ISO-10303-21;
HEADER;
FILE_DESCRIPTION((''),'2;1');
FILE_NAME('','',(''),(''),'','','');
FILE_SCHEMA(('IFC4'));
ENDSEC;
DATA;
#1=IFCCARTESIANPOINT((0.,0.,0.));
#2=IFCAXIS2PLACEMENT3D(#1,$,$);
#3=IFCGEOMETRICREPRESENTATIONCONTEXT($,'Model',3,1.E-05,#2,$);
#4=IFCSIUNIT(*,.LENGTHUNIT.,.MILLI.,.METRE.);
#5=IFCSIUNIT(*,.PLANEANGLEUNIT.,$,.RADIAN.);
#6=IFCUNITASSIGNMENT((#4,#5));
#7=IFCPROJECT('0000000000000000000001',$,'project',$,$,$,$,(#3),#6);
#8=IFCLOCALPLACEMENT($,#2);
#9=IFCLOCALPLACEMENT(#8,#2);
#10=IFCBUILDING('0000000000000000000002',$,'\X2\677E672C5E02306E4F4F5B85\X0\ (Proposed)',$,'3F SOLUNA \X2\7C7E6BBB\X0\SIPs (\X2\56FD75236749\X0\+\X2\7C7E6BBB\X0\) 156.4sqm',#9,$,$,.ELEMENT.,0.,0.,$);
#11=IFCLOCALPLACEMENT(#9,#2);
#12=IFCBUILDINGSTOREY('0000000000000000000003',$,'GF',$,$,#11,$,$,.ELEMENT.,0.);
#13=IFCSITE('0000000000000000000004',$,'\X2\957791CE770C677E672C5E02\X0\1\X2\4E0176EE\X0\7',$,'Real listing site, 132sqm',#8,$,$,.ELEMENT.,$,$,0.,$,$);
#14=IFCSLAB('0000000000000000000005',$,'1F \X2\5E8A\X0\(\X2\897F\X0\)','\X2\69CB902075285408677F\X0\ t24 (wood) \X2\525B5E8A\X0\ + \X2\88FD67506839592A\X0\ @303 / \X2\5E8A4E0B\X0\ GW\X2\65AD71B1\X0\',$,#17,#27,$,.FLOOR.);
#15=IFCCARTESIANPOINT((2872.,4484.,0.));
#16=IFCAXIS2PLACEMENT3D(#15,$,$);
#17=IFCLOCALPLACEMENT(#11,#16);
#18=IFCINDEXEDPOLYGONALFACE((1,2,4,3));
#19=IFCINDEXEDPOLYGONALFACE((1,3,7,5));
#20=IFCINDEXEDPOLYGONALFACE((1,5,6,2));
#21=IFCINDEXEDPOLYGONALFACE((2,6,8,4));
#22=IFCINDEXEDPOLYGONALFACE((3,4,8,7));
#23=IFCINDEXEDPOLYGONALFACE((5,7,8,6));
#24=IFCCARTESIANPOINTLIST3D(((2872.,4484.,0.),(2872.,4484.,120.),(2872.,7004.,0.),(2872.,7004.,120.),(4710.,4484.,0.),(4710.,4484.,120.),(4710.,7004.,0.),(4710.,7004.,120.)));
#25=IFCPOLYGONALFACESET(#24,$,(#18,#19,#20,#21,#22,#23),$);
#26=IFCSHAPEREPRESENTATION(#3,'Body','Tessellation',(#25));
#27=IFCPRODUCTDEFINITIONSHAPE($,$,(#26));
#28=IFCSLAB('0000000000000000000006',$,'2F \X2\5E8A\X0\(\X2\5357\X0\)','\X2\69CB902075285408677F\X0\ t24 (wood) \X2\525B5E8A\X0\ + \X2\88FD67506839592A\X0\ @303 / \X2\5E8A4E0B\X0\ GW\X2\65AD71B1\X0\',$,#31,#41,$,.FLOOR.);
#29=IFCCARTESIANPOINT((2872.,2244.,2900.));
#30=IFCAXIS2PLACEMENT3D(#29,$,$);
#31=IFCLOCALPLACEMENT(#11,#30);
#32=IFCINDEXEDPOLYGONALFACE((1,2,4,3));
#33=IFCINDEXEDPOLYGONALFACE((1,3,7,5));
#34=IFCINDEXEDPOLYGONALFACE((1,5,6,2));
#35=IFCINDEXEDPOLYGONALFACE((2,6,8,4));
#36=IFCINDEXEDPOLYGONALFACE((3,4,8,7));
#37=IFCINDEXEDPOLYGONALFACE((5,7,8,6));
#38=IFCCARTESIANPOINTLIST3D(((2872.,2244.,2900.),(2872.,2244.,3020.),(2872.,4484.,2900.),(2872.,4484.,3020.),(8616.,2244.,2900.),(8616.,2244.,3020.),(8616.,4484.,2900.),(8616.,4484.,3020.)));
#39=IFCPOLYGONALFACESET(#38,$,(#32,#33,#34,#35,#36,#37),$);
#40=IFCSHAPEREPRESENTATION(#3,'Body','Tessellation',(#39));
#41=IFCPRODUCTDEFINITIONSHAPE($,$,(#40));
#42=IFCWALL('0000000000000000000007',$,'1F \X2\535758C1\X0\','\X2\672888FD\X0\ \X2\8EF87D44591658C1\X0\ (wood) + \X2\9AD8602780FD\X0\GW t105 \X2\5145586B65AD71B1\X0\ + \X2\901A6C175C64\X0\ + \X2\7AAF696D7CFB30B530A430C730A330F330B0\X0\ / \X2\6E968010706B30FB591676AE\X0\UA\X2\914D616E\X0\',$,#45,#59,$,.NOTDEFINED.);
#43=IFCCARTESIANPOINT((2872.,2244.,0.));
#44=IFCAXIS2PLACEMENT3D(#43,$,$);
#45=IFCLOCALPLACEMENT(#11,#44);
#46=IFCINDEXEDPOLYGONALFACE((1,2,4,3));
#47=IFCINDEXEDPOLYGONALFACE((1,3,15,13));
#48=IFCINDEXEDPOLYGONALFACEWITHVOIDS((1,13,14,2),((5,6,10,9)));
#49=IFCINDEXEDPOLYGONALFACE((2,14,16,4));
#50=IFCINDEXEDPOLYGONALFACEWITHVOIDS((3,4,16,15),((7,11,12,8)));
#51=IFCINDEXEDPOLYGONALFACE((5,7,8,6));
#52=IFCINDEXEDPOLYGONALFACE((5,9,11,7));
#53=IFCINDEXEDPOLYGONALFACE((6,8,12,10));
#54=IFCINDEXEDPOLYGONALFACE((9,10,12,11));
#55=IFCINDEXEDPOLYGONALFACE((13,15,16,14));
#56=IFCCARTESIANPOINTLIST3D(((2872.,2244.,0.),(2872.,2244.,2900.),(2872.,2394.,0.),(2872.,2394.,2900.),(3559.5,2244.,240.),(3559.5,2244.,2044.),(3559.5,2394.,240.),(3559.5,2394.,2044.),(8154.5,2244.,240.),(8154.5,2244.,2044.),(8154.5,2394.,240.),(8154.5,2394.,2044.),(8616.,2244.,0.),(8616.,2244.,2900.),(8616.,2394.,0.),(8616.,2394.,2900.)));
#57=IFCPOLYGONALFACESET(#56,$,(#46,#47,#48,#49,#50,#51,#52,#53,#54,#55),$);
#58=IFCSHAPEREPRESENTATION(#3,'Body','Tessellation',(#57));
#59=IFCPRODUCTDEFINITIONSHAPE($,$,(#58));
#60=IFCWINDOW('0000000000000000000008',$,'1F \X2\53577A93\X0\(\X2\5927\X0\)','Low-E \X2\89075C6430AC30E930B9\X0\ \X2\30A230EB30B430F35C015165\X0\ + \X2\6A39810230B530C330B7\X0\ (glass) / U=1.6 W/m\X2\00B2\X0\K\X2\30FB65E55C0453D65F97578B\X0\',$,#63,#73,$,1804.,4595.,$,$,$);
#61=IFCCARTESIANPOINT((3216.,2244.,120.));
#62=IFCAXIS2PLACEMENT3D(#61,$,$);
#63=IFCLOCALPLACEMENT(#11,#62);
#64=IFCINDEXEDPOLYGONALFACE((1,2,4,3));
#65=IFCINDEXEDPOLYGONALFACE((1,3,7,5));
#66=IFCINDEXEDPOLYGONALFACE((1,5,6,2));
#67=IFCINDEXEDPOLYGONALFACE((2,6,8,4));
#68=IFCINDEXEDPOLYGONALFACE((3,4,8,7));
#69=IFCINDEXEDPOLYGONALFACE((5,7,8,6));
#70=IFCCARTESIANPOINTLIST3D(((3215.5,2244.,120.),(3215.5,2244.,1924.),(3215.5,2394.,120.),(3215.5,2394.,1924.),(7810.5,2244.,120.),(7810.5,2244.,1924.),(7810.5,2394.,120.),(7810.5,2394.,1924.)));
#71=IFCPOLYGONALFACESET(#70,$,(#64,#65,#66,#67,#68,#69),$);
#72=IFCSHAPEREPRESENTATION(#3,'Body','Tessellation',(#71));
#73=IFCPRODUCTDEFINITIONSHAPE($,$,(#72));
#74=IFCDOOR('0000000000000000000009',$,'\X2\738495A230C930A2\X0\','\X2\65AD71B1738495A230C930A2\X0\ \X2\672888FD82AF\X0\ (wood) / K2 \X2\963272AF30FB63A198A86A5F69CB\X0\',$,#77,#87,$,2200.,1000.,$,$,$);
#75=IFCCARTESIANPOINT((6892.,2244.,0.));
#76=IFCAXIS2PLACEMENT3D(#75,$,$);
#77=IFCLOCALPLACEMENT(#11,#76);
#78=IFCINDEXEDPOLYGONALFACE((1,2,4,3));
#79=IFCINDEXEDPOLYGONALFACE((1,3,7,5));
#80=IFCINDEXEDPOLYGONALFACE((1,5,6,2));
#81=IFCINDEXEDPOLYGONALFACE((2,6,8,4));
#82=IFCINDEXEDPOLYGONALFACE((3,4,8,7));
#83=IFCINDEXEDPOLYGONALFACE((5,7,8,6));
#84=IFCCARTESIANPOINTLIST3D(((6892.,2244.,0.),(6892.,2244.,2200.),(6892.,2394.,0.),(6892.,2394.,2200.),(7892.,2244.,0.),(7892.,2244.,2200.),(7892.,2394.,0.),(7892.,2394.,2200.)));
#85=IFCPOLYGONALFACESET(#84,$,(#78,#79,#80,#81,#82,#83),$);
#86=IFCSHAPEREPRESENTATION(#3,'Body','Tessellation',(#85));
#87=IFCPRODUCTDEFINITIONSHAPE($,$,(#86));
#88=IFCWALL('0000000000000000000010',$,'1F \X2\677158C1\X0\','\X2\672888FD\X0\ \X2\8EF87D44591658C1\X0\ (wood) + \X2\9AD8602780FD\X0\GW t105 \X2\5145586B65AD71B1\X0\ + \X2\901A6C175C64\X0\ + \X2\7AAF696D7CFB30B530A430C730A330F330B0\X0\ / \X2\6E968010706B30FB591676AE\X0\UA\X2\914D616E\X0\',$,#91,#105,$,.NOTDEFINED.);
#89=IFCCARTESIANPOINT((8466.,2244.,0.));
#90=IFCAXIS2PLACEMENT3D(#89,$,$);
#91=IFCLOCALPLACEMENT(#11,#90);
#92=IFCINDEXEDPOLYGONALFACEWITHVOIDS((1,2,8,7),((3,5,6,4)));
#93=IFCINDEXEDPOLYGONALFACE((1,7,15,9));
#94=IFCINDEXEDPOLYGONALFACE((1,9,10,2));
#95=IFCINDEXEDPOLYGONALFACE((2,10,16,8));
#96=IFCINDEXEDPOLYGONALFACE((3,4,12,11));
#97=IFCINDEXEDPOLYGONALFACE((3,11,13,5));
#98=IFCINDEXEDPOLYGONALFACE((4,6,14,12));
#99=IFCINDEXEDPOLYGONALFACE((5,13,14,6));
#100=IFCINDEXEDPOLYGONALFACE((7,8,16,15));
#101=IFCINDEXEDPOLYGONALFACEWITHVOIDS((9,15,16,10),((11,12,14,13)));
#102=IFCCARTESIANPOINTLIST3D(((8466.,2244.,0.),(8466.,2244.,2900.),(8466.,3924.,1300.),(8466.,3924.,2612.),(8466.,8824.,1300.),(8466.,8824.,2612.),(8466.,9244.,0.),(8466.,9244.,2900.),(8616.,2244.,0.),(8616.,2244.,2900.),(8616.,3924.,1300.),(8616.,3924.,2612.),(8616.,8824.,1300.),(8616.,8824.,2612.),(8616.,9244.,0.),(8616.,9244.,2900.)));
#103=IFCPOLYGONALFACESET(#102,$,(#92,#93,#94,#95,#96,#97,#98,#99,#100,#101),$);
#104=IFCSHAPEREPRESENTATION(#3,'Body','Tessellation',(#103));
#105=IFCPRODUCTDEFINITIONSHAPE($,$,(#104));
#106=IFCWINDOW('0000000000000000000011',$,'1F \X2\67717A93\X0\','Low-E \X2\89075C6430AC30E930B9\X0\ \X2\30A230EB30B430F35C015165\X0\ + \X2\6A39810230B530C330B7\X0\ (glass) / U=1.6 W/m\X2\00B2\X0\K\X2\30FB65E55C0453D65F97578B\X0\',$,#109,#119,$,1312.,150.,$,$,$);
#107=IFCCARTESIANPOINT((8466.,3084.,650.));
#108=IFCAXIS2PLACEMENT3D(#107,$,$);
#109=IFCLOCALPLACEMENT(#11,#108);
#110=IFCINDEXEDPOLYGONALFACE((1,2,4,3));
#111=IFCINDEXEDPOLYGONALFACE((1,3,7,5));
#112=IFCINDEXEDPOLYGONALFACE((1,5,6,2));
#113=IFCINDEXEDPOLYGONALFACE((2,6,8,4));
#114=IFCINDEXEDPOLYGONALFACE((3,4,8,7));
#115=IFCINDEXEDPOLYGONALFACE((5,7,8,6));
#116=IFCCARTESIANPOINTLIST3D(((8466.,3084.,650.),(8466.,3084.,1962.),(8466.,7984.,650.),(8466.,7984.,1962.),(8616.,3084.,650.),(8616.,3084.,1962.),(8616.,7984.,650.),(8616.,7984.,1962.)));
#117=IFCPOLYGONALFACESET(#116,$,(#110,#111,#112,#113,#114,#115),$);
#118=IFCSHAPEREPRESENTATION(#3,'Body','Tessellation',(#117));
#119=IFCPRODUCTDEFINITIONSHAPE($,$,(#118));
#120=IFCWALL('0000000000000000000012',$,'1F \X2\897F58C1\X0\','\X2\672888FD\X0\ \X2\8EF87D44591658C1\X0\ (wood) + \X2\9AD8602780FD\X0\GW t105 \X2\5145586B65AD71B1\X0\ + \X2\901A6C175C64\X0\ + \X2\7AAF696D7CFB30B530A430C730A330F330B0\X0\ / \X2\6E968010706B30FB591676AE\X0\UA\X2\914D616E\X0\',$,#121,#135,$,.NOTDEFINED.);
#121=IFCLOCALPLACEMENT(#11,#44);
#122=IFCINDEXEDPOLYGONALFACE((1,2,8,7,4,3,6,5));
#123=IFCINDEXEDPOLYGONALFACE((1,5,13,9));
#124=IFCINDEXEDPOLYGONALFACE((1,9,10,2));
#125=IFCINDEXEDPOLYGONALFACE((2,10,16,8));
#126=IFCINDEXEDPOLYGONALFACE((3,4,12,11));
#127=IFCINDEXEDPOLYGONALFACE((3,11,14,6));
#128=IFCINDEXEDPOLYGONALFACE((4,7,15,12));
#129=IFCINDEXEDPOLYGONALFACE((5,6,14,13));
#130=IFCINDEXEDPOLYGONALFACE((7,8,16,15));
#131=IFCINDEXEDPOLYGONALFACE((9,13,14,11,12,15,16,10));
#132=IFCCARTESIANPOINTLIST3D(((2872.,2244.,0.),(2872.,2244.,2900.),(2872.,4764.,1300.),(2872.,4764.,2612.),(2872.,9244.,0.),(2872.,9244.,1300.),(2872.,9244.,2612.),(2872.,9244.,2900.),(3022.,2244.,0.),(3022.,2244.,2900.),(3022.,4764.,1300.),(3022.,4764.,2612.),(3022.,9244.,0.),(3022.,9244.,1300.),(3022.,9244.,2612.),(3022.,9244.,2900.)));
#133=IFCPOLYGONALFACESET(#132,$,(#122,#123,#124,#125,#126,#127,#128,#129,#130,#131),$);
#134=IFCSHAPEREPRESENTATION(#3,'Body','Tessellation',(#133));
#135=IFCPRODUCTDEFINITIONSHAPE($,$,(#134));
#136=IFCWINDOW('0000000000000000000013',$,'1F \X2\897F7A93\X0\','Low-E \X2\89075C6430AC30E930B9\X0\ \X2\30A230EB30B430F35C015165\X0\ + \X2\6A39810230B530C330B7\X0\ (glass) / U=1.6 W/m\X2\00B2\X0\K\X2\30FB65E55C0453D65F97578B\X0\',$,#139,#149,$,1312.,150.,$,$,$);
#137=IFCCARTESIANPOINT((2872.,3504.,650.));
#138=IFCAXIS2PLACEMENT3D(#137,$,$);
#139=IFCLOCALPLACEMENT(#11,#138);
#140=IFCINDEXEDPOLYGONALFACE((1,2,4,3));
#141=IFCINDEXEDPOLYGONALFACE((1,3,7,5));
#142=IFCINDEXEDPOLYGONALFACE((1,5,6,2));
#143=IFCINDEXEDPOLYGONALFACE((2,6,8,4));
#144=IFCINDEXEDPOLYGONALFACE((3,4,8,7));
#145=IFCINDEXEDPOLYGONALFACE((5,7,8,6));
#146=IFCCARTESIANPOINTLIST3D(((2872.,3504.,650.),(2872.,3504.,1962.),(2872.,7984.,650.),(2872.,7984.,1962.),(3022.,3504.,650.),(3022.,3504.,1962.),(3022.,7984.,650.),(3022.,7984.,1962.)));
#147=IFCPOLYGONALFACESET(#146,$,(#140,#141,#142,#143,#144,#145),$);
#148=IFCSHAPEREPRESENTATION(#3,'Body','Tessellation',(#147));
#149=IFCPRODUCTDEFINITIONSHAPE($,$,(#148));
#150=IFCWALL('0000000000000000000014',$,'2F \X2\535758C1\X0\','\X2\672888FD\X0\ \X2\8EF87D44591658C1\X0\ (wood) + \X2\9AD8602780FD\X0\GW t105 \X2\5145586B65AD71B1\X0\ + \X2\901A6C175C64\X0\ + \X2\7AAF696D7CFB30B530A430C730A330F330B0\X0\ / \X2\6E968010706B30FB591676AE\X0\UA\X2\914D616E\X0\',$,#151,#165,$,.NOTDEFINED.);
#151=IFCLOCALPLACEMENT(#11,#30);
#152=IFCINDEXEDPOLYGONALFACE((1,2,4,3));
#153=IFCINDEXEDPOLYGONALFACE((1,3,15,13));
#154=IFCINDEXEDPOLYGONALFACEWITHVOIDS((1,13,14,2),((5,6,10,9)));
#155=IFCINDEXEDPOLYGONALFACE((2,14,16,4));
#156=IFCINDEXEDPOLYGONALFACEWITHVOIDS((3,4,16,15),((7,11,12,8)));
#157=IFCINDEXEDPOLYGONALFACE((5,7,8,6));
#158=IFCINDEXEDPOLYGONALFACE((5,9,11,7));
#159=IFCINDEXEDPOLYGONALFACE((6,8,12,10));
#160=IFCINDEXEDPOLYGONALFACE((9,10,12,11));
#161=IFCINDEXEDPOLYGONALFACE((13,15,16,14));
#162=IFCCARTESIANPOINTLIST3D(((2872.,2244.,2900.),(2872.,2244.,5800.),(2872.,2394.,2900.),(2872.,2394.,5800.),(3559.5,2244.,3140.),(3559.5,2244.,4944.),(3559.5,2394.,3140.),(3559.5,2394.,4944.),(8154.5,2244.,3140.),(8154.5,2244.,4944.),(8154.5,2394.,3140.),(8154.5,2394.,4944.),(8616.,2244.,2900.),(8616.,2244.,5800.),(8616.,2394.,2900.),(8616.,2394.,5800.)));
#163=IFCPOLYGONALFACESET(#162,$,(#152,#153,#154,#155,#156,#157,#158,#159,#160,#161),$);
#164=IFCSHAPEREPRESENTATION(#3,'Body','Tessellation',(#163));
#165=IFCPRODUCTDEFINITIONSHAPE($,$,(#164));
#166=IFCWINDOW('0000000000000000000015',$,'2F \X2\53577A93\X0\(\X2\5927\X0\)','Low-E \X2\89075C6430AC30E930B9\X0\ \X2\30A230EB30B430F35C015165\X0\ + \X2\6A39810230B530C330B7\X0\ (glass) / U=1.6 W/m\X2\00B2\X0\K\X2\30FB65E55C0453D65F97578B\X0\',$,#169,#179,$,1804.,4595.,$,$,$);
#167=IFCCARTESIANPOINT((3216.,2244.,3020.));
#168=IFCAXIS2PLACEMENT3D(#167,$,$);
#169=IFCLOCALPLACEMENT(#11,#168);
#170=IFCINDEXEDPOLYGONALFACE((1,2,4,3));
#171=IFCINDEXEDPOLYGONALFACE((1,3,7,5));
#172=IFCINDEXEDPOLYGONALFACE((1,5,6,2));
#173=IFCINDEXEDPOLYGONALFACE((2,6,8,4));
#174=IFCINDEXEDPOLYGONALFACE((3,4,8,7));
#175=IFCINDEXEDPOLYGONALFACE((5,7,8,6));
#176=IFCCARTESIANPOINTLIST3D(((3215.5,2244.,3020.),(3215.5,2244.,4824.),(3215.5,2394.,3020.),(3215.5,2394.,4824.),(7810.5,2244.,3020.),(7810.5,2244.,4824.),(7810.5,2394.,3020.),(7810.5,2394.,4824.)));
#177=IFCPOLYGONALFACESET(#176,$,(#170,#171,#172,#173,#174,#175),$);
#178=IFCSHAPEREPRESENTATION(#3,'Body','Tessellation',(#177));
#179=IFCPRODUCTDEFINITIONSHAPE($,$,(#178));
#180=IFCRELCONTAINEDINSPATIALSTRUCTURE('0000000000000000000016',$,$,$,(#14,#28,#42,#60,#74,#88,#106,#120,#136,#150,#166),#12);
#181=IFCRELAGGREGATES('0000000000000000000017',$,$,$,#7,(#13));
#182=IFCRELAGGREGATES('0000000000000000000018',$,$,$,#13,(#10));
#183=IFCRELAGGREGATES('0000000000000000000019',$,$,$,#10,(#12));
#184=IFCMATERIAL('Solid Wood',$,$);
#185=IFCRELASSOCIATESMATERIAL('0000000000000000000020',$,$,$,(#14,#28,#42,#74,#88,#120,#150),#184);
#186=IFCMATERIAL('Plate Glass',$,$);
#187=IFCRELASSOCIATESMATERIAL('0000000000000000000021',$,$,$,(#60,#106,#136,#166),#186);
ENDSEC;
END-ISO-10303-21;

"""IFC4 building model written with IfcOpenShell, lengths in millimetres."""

from ifc_helpers import new_model, si_unit, frame, frame_2d, origin, place, context, project, spatial, rectangle, extrude, material, element, fill, save


model = new_model("IFC4")

# Units and contexts
model_context = context("Model", 3, precision=1e-05, world=origin())
ifc_project = project(units=[si_unit("LENGTHUNIT", "METRE", prefix="MILLI"), si_unit("PLANEANGLEUNIT", "RADIAN")], contexts=[model_context])

# Site, building, storey
site_placement = place(None, origin())
site = spatial("IfcSite", under=ifc_project, at=site_placement, Name="長野県松本市1丁目7", ObjectType="Real listing site, 132sqm", CompositionType="ELEMENT", RefElevation=0.0)
building_placement = place(site_placement, origin())
building = spatial("IfcBuilding", under=site, at=building_placement, Name="松本市の住宅 (Proposed)", ObjectType="3F SOLUNA 籾殻SIPs (国産杉+籾殻) 156.4sqm", CompositionType="ELEMENT", ElevationOfRefHeight=0.0, ElevationOfTerrain=0.0)
storey_placement = place(building_placement, origin())
storey = spatial("IfcBuildingStorey", under=building, at=storey_placement, Name="GF", CompositionType="ELEMENT", Elevation=0.0)

# Slabs
ifc_material_1 = material(Name="Solid Wood")
slab_1_placement = place(storey_placement, frame((2872.0, 4484.0, 0.0)))
element("IfcSlab", 1, at=slab_1_placement, inside=storey, material=ifc_material_1, Name="1F 床(西)", Description="構造用合板 t24 (wood) 剛床 + 製材根太 @303 / 床下 GW断熱", PredefinedType="FLOOR", context=model_context, shape_type="SweptSolid", body=[
    extrude(rectangle(XDim=1838.0, YDim=2520.0, at=frame_2d((919.0, 1260.0))), frame((2872.0, 4484.0, 0.0)), (0.0, 0.0, 1.0), 120.0),
])
slab_2_placement = place(storey_placement, frame((2872.0, 2244.0, 2900.0)))
element("IfcSlab", 2, at=slab_2_placement, inside=storey, material=ifc_material_1, Name="2F 床(南)", Description="構造用合板 t24 (wood) 剛床 + 製材根太 @303 / 床下 GW断熱", PredefinedType="FLOOR", context=model_context, shape_type="SweptSolid", body=[
    extrude(rectangle(XDim=5744.0, YDim=2240.0, at=frame_2d((2872.0, 1120.0))), frame((2872.0, 2244.0, 2900.0)), (0.0, 0.0, 1.0), 120.0),
])

# Wall, openings, window, door
wall_1_placement = place(storey_placement, frame((2872.0, 2244.0, 0.0)))
wall_1 = element("IfcWall", 3, at=wall_1_placement, inside=storey, material=ifc_material_1, Name="1F 南壁", Description="木製 軸組外壁 (wood) + 高性能GW t105 充填断熱 + 通気層 + 窯業系サイディング / 準耐火・外皮UA配慮", PredefinedType="NOTDEFINED", context=model_context, shape_type="SweptSolid", body=[
    extrude(rectangle(XDim=5744.0, YDim=150.0, at=frame_2d((2872.0, 75.0))), frame((2872.0, 2244.0, 0.0)), (0.0, 0.0, 1.0), 2900.0),
])
opening_1_placement = place(storey_placement, frame((3216.0, 2244.0, 120.0)))
opening_1 = element("IfcOpeningElement", 4, at=opening_1_placement, cuts=wall_1, PredefinedType="NOTDEFINED", context=model_context, shape_type="SweptSolid", body=[
    extrude(rectangle(XDim=4595.0, YDim=150.0, at=frame_2d((2297.0, 75.0))), frame((3216.0, 2244.0, 120.0)), (0.0, 0.0, 1.0), 1804.0),
])
opening_2_placement = place(storey_placement, frame((6892.0, 2244.0, 0.0)))
opening_2 = element("IfcOpeningElement", 5, at=opening_2_placement, cuts=wall_1, PredefinedType="NOTDEFINED", context=model_context, shape_type="SweptSolid", body=[
    extrude(rectangle(XDim=1000.0, YDim=150.0, at=frame_2d((500.0, 75.0))), frame((6892.0, 2244.0, 0.0)), (0.0, 0.0, 1.0), 2200.0),
])
ifc_material_2 = material(Name="Plate Glass")
window_1_placement = place(storey_placement, frame((3216.0, 2244.0, 120.0)))
window_1 = element("IfcWindow", 6, at=window_1_placement, inside=storey, material=ifc_material_2, Name="1F 南窓(大)", Description="Low-E 複層ガラス アルゴン封入 + 樹脂サッシ (glass) / U=1.6 W/m²K・日射取得型", OverallHeight=1804.0, OverallWidth=4595.0, context=model_context, shape_type="SweptSolid", body=[
    extrude(rectangle(XDim=4595.0, YDim=150.0, at=frame_2d((2297.0, 75.0))), frame((3216.0, 2244.0, 120.0)), (0.0, 0.0, 1.0), 1804.0),
])
fill(opening_1, window_1)
door_placement = place(storey_placement, frame((6892.0, 2244.0, 0.0)))
door = element("IfcDoor", 7, at=door_placement, inside=storey, material=ifc_material_1, Name="玄関ドア", Description="断熱玄関ドア 木製芯 (wood) / K2 防犯・採風機構", OverallHeight=2200.0, OverallWidth=1000.0, context=model_context, shape_type="SweptSolid", body=[
    extrude(rectangle(XDim=1000.0, YDim=150.0, at=frame_2d((500.0, 75.0))), frame((6892.0, 2244.0, 0.0)), (0.0, 0.0, 1.0), 2200.0),
])
fill(opening_2, door)

# Walls, openings, windows
wall_2_placement = place(storey_placement, frame((8466.0, 2244.0, 0.0)))
wall_2 = element("IfcWall", 8, at=wall_2_placement, inside=storey, material=ifc_material_1, Name="1F 東壁", Description="木製 軸組外壁 (wood) + 高性能GW t105 充填断熱 + 通気層 + 窯業系サイディング / 準耐火・外皮UA配慮", PredefinedType="NOTDEFINED", context=model_context, shape_type="SweptSolid", body=[
    extrude(rectangle(XDim=150.0, YDim=7000.0, at=frame_2d((75.0, 3500.0))), frame((8466.0, 2244.0, 0.0)), (0.0, 0.0, 1.0), 2900.0),
])
opening_3_placement = place(storey_placement, frame((8466.0, 3084.0, 650.0)))
opening_3 = element("IfcOpeningElement", 9, at=opening_3_placement, cuts=wall_2, PredefinedType="NOTDEFINED", context=model_context, shape_type="SweptSolid", body=[
    extrude(rectangle(XDim=150.0, YDim=4900.0, at=frame_2d((75.0, 2450.0))), frame((8466.0, 3084.0, 650.0)), (0.0, 0.0, 1.0), 1312.0),
])
window_2_placement = place(storey_placement, frame((8466.0, 3084.0, 650.0)))
window_2 = element("IfcWindow", 10, at=window_2_placement, inside=storey, material=ifc_material_2, Name="1F 東窓", Description="Low-E 複層ガラス アルゴン封入 + 樹脂サッシ (glass) / U=1.6 W/m²K・日射取得型", OverallHeight=1312.0, OverallWidth=150.0, context=model_context, shape_type="SweptSolid", body=[
    extrude(rectangle(XDim=150.0, YDim=4900.0, at=frame_2d((75.0, 2450.0))), frame((8466.0, 3084.0, 650.0)), (0.0, 0.0, 1.0), 1312.0),
])
fill(opening_3, window_2)
wall_3_placement = place(storey_placement, frame((2872.0, 2244.0, 0.0)))
wall_3 = element("IfcWall", 11, at=wall_3_placement, inside=storey, material=ifc_material_1, Name="1F 西壁", Description="木製 軸組外壁 (wood) + 高性能GW t105 充填断熱 + 通気層 + 窯業系サイディング / 準耐火・外皮UA配慮", PredefinedType="NOTDEFINED", context=model_context, shape_type="SweptSolid", body=[
    extrude(rectangle(XDim=150.0, YDim=7000.0, at=frame_2d((75.0, 3500.0))), frame((2872.0, 2244.0, 0.0)), (0.0, 0.0, 1.0), 2900.0),
])
opening_4_placement = place(storey_placement, frame((2872.0, 3504.0, 650.0)))
opening_4 = element("IfcOpeningElement", 12, at=opening_4_placement, cuts=wall_3, PredefinedType="NOTDEFINED", context=model_context, shape_type="SweptSolid", body=[
    extrude(rectangle(XDim=150.0, YDim=4480.0, at=frame_2d((75.0, 2240.0))), frame((2872.0, 3504.0, 650.0)), (0.0, 0.0, 1.0), 1312.0),
])
window_3_placement = place(storey_placement, frame((2872.0, 3504.0, 650.0)))
window_3 = element("IfcWindow", 13, at=window_3_placement, inside=storey, material=ifc_material_2, Name="1F 西窓", Description="Low-E 複層ガラス アルゴン封入 + 樹脂サッシ (glass) / U=1.6 W/m²K・日射取得型", OverallHeight=1312.0, OverallWidth=150.0, context=model_context, shape_type="SweptSolid", body=[
    extrude(rectangle(XDim=150.0, YDim=4480.0, at=frame_2d((75.0, 2240.0))), frame((2872.0, 3504.0, 650.0)), (0.0, 0.0, 1.0), 1312.0),
])
fill(opening_4, window_3)
wall_4_placement = place(storey_placement, frame((2872.0, 2244.0, 2900.0)))
wall_4 = element("IfcWall", 14, at=wall_4_placement, inside=storey, material=ifc_material_1, Name="2F 南壁", Description="木製 軸組外壁 (wood) + 高性能GW t105 充填断熱 + 通気層 + 窯業系サイディング / 準耐火・外皮UA配慮", PredefinedType="NOTDEFINED", context=model_context, shape_type="SweptSolid", body=[
    extrude(rectangle(XDim=5744.0, YDim=150.0, at=frame_2d((2872.0, 75.0))), frame((2872.0, 2244.0, 2900.0)), (0.0, 0.0, 1.0), 2900.0),
])
opening_5_placement = place(storey_placement, frame((3216.0, 2244.0, 3020.0)))
opening_5 = element("IfcOpeningElement", 15, at=opening_5_placement, cuts=wall_4, PredefinedType="NOTDEFINED", context=model_context, shape_type="SweptSolid", body=[
    extrude(rectangle(XDim=4595.0, YDim=150.0, at=frame_2d((2297.0, 75.0))), frame((3216.0, 2244.0, 3020.0)), (0.0, 0.0, 1.0), 1804.0),
])
window_4_placement = place(storey_placement, frame((3216.0, 2244.0, 3020.0)))
window_4 = element("IfcWindow", 16, at=window_4_placement, inside=storey, material=ifc_material_2, Name="2F 南窓(大)", Description="Low-E 複層ガラス アルゴン封入 + 樹脂サッシ (glass) / U=1.6 W/m²K・日射取得型", OverallHeight=1804.0, OverallWidth=4595.0, context=model_context, shape_type="SweptSolid", body=[
    extrude(rectangle(XDim=4595.0, YDim=150.0, at=frame_2d((2297.0, 75.0))), frame((3216.0, 2244.0, 3020.0)), (0.0, 0.0, 1.0), 1804.0),
])
fill(opening_5, window_4)

save(model, "model.ifc")
